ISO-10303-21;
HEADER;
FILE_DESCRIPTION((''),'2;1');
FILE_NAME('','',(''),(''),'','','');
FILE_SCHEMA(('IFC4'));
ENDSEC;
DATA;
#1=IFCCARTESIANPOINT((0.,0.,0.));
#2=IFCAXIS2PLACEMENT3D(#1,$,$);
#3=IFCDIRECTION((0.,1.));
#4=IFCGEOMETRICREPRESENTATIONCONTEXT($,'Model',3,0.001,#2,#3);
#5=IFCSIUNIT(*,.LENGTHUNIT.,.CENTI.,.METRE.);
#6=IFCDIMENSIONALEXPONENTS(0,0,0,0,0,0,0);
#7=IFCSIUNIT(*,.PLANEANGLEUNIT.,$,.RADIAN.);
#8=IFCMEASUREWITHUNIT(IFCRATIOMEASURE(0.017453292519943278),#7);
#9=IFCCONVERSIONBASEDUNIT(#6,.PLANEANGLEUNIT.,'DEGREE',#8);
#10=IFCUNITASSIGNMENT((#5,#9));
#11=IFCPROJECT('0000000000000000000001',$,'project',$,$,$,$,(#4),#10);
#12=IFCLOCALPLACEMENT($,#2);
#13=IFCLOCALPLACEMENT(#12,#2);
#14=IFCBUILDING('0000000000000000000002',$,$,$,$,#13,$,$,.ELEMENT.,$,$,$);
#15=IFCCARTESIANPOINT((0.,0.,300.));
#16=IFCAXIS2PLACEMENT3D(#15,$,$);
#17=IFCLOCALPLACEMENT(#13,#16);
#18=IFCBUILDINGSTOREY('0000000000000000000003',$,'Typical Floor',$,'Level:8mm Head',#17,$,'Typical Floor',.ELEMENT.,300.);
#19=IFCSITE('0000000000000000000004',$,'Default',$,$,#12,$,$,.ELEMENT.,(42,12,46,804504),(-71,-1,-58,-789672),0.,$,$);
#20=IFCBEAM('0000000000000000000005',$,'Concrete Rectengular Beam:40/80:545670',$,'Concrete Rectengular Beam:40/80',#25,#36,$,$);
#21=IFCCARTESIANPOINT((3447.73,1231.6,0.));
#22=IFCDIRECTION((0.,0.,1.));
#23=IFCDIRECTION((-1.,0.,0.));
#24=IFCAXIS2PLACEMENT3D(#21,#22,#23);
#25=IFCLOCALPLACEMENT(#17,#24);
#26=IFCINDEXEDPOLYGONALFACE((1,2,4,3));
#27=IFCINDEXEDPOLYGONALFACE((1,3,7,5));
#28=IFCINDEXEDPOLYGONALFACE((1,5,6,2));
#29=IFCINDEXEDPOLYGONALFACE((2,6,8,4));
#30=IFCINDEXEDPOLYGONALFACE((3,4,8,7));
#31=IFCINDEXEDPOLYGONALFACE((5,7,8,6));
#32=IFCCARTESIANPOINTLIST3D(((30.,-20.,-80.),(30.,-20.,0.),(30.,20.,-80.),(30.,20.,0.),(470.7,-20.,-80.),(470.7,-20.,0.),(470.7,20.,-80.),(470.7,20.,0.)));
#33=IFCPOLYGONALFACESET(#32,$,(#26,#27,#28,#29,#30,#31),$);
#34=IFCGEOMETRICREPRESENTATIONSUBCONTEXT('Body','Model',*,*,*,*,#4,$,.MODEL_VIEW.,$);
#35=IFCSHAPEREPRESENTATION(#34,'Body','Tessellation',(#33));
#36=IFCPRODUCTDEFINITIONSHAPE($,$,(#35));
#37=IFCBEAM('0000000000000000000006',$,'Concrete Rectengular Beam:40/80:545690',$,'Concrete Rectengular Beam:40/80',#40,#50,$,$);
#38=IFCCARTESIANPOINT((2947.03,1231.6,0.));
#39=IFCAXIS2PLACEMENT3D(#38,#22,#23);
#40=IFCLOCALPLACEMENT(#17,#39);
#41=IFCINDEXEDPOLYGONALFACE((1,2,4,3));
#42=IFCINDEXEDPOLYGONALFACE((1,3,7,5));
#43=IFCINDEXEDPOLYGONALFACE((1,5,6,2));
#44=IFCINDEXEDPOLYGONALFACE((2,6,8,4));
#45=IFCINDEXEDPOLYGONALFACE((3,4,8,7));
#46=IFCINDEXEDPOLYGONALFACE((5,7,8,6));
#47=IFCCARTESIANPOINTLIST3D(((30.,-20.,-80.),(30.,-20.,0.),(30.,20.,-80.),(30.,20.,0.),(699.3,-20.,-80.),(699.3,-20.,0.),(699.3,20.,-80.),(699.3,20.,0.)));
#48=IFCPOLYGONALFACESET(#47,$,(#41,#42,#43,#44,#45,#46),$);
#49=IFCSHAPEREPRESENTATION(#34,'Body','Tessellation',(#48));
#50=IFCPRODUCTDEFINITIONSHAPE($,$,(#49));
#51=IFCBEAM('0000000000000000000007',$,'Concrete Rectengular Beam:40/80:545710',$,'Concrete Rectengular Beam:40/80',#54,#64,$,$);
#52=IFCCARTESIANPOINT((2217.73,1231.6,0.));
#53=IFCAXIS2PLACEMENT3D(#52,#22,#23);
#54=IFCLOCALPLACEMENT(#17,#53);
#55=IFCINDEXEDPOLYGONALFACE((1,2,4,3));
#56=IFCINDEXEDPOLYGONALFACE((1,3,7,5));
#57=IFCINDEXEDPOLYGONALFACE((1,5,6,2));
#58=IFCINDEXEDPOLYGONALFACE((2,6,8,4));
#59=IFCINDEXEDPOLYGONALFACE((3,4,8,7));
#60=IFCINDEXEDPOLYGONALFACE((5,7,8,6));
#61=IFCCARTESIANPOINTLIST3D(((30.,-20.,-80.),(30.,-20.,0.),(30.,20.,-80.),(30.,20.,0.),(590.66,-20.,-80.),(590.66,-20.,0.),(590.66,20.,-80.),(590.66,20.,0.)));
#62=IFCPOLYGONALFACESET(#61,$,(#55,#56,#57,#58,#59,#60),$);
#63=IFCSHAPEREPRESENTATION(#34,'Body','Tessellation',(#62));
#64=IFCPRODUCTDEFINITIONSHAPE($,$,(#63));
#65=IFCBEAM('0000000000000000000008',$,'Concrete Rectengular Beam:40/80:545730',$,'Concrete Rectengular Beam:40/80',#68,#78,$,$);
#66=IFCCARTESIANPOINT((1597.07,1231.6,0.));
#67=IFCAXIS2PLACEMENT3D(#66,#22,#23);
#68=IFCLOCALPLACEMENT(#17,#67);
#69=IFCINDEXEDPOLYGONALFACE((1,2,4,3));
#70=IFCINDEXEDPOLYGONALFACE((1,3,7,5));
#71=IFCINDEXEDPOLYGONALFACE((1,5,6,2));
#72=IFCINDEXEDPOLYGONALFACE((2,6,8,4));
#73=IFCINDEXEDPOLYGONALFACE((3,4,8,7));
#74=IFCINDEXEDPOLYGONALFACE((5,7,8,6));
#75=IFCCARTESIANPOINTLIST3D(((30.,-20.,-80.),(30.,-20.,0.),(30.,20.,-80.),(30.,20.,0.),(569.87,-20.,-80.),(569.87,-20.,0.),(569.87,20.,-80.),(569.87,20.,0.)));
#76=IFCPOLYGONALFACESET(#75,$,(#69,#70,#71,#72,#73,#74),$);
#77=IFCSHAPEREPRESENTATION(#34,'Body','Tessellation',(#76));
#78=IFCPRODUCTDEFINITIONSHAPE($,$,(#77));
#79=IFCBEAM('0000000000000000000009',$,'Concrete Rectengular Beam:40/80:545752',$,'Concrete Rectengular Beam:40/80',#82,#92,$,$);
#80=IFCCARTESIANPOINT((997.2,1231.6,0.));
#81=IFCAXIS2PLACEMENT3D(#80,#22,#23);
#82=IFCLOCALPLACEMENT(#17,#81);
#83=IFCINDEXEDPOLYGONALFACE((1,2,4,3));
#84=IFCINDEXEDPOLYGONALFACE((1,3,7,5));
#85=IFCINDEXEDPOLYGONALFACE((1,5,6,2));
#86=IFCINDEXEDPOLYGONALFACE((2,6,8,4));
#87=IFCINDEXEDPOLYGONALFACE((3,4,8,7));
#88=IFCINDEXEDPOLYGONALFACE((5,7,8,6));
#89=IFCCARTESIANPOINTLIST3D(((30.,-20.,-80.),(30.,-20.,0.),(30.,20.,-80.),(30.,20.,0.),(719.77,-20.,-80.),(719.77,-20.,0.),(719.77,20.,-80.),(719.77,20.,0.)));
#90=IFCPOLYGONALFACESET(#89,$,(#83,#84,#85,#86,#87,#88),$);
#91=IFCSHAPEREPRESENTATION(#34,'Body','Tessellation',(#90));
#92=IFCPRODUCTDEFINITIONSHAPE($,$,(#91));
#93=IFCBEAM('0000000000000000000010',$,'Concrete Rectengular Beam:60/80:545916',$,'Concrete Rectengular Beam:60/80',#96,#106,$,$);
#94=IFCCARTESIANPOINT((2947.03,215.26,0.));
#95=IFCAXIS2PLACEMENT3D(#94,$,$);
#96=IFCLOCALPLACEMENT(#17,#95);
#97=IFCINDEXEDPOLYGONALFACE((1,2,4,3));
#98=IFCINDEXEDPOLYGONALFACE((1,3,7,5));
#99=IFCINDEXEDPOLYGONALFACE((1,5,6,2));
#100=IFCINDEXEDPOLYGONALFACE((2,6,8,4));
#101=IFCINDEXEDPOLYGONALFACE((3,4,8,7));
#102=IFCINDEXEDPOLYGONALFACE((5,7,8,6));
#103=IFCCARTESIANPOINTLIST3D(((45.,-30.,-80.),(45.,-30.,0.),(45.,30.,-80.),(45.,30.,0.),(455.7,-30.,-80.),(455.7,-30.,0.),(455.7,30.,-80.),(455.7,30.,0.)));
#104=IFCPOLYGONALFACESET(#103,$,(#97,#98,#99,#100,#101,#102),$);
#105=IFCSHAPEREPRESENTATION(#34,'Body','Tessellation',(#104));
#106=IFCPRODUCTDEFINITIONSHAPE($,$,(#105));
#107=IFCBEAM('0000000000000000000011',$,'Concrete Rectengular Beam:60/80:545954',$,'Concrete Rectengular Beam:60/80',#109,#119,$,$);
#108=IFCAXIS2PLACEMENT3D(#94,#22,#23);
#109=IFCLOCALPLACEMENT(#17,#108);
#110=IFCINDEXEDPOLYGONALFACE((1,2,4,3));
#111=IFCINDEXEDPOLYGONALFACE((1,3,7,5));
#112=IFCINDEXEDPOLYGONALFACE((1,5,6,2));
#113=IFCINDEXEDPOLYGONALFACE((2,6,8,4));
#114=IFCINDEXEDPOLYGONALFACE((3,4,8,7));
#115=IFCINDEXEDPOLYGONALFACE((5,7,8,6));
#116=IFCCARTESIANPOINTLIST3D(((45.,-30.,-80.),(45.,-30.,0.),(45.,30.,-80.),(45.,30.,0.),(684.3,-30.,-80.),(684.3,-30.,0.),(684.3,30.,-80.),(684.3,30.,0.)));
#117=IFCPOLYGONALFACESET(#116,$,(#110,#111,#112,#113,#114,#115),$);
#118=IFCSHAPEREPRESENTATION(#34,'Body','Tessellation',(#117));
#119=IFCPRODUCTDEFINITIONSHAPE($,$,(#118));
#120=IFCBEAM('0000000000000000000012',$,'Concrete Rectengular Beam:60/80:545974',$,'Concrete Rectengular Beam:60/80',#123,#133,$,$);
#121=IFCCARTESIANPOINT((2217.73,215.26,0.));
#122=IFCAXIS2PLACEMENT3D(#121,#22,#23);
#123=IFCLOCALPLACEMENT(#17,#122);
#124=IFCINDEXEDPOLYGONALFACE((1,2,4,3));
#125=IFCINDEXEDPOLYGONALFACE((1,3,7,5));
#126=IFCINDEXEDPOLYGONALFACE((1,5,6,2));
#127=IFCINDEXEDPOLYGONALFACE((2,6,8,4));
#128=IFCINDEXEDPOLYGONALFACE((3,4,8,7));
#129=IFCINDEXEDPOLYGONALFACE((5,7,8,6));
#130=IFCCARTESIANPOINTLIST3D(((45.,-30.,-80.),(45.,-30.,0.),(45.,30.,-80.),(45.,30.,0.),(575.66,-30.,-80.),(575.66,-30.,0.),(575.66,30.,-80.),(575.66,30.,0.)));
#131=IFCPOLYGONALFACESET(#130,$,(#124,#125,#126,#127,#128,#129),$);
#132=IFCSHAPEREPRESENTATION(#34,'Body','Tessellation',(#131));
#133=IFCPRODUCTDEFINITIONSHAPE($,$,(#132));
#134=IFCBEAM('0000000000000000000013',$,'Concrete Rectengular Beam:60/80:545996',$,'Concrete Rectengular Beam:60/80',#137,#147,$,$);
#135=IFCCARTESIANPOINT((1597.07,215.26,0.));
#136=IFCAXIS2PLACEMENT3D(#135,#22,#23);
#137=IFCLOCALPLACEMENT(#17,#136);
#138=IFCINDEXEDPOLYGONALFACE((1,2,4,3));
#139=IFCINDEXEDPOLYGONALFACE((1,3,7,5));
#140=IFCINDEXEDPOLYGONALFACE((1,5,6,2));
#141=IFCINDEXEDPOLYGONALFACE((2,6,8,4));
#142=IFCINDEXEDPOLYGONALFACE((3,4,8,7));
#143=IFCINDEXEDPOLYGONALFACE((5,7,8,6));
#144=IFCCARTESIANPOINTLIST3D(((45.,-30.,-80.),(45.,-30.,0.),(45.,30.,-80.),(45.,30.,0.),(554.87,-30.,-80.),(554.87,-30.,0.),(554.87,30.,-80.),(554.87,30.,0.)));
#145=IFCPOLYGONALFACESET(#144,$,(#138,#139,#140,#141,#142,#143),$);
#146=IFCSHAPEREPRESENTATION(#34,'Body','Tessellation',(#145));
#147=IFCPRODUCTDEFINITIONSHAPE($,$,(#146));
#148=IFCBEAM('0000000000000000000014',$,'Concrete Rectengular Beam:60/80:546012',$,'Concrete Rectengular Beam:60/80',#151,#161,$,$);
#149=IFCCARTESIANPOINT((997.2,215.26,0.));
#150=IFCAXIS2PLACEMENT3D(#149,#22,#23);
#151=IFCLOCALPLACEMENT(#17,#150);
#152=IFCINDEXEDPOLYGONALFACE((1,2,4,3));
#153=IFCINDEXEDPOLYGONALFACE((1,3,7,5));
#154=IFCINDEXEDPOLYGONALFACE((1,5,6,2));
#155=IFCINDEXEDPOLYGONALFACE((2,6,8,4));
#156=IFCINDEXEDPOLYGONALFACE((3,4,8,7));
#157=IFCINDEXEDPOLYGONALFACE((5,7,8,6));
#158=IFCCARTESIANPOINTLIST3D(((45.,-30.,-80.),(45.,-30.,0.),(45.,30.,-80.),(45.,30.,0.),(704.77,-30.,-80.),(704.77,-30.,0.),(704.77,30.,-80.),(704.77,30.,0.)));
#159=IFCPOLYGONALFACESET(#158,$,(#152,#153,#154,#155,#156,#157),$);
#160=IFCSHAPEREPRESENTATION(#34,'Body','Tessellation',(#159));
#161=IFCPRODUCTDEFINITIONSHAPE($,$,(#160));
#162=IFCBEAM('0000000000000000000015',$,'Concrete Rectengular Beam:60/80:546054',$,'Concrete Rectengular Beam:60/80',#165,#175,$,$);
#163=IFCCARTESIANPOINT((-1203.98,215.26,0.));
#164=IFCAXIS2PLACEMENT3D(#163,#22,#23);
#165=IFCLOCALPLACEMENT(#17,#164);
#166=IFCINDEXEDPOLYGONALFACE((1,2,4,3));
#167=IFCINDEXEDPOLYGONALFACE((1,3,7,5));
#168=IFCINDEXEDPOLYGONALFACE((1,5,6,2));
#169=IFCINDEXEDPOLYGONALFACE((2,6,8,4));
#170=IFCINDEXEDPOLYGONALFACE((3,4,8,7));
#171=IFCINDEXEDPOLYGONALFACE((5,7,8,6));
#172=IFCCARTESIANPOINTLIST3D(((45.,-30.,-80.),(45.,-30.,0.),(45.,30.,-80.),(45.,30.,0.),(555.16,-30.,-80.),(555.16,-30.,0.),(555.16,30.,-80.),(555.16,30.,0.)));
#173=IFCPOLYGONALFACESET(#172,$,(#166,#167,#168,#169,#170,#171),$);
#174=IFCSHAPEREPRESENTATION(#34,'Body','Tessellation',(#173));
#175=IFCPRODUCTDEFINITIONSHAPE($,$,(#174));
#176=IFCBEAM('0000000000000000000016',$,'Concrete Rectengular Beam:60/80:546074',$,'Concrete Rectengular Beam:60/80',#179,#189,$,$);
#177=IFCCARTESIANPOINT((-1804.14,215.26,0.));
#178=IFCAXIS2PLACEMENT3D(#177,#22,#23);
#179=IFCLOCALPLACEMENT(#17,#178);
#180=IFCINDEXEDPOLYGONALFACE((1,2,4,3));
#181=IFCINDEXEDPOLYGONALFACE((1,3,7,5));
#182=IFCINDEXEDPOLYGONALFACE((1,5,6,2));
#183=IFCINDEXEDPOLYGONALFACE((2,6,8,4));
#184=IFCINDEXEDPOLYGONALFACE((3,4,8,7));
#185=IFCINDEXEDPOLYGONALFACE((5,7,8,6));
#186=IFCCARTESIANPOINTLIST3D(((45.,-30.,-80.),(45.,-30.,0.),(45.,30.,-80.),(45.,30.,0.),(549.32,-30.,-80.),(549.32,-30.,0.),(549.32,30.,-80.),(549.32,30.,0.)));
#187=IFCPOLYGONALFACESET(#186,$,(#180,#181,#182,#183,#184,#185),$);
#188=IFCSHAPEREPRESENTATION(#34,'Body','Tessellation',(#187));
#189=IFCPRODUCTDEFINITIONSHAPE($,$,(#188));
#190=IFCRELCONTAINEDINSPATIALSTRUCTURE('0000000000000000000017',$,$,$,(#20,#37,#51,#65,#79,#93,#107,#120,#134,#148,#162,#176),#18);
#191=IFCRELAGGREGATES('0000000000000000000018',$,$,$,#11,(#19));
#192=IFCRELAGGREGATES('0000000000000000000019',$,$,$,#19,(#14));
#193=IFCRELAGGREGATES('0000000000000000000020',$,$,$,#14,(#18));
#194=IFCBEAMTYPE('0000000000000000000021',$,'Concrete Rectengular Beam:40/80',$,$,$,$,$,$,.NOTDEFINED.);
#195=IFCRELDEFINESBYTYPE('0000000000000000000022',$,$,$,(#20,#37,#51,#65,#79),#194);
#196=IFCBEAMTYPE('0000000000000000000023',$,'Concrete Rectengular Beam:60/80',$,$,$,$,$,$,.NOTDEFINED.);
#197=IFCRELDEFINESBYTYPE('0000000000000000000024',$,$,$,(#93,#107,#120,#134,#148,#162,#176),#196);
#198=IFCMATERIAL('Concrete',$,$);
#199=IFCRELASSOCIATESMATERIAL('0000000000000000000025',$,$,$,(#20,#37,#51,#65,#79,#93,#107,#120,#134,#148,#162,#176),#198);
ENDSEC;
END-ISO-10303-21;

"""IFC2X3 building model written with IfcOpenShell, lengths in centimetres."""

from ifc_helpers import new_model, entity, si_unit, converted_unit, direction, frame, frame_2d, origin, place, context, subcontext, project, spatial, rectangle, extrude, material, type_object, element, save


model = new_model("IFC2X3")

# Units and contexts
model_context = context("Model", 3, precision=0.001, world=origin(), true_north=direction((0.0, 1.0)))
body_context = subcontext(model_context, "Body", "Model", "MODEL_VIEW")
ifc_project = project(units=[si_unit("LENGTHUNIT", "METRE", prefix="CENTI"), converted_unit("PLANEANGLEUNIT", "DEGREE", entity("IfcRatioMeasure", 0.017453292519943278), si_unit("PLANEANGLEUNIT", "RADIAN"), dimensions=[0, 0, 0, 0, 0, 0, 0])], contexts=[model_context])

# Site, building, storey
site_placement = place(None, origin())
site = spatial("IfcSite", under=ifc_project, at=site_placement, Name="Default", CompositionType="ELEMENT", RefLatitude=(42, 12, 46, 804504), RefLongitude=(-71, -1, -58, -789672), RefElevation=0.0)
building_placement = place(site_placement, origin())
building = spatial("IfcBuilding", under=site, at=building_placement, CompositionType="ELEMENT")
storey_placement = place(building_placement, frame((0.0, 0.0, 300.0)))
storey = spatial("IfcBuildingStorey", under=building, at=storey_placement, Name="Typical Floor", ObjectType="Level:8mm Head", LongName="Typical Floor", CompositionType="ELEMENT", Elevation=300.0)

# Beams
ifc_material = material(Name="Concrete")
beam_type_1 = type_object("IfcBeamType", Name="Concrete Rectengular Beam:40/80", PredefinedType="NOTDEFINED")
beam_1_placement = place(storey_placement, frame((3447.73, 1231.6, 0.0), z_axis=(0.0, 0.0, 1.0), x_axis=(-1.0, 0.0, 0.0)))
element("IfcBeam", 1, at=beam_1_placement, inside=storey, type_object=beam_type_1, material=ifc_material, Name="Concrete Rectengular Beam:40/80:545670", ObjectType="Concrete Rectengular Beam:40/80", context=body_context, shape_type="SweptSolid", body=[
    extrude(rectangle(XDim=80.0, YDim=40.0, at=frame_2d((0.0, 0.0), x_axis=(1.0, 0.0))), frame((30.0, 0.0, -40.0), z_axis=(1.0, 0.0, 0.0), x_axis=(0.0, 0.0, -1.0)), (0.0, 0.0, 1.0), 440.7),
])
beam_2_placement = place(storey_placement, frame((2947.03, 1231.6, 0.0), z_axis=(0.0, 0.0, 1.0), x_axis=(-1.0, 0.0, 0.0)))
element("IfcBeam", 2, at=beam_2_placement, inside=storey, type_object=beam_type_1, material=ifc_material, Name="Concrete Rectengular Beam:40/80:545690", ObjectType="Concrete Rectengular Beam:40/80", context=body_context, shape_type="SweptSolid", body=[
    extrude(rectangle(XDim=80.0, YDim=40.0, at=frame_2d((0.0, 0.0), x_axis=(1.0, 0.0))), frame((30.0, 0.0, -40.0), z_axis=(1.0, 0.0, 0.0), x_axis=(0.0, 0.0, -1.0)), (0.0, 0.0, 1.0), 669.3),
])
beam_3_placement = place(storey_placement, frame((2217.73, 1231.6, 0.0), z_axis=(0.0, 0.0, 1.0), x_axis=(-1.0, 0.0, 0.0)))
element("IfcBeam", 3, at=beam_3_placement, inside=storey, type_object=beam_type_1, material=ifc_material, Name="Concrete Rectengular Beam:40/80:545710", ObjectType="Concrete Rectengular Beam:40/80", context=body_context, shape_type="SweptSolid", body=[
    extrude(rectangle(XDim=80.0, YDim=40.0, at=frame_2d((0.0, 0.0), x_axis=(1.0, 0.0))), frame((30.0, 0.0, -40.0), z_axis=(1.0, 0.0, 0.0), x_axis=(0.0, 0.0, -1.0)), (0.0, 0.0, 1.0), 560.66),
])
beam_4_placement = place(storey_placement, frame((1597.07, 1231.6, 0.0), z_axis=(0.0, 0.0, 1.0), x_axis=(-1.0, 0.0, 0.0)))
element("IfcBeam", 4, at=beam_4_placement, inside=storey, type_object=beam_type_1, material=ifc_material, Name="Concrete Rectengular Beam:40/80:545730", ObjectType="Concrete Rectengular Beam:40/80", context=body_context, shape_type="SweptSolid", body=[
    extrude(rectangle(XDim=80.0, YDim=40.0, at=frame_2d((0.0, 0.0), x_axis=(1.0, 0.0))), frame((30.0, 0.0, -40.0), z_axis=(1.0, 0.0, 0.0), x_axis=(0.0, 0.0, -1.0)), (0.0, 0.0, 1.0), 539.87),
])
beam_5_placement = place(storey_placement, frame((997.2, 1231.6, 0.0), z_axis=(0.0, 0.0, 1.0), x_axis=(-1.0, 0.0, 0.0)))
element("IfcBeam", 5, at=beam_5_placement, inside=storey, type_object=beam_type_1, material=ifc_material, Name="Concrete Rectengular Beam:40/80:545752", ObjectType="Concrete Rectengular Beam:40/80", context=body_context, shape_type="SweptSolid", body=[
    extrude(rectangle(XDim=80.0, YDim=40.0, at=frame_2d((0.0, 0.0), x_axis=(1.0, 0.0))), frame((30.0, 0.0, -40.0), z_axis=(1.0, 0.0, 0.0), x_axis=(0.0, 0.0, -1.0)), (0.0, 0.0, 1.0), 689.77),
])
beam_type_2 = type_object("IfcBeamType", Name="Concrete Rectengular Beam:60/80", PredefinedType="NOTDEFINED")
beam_6_placement = place(storey_placement, frame((2947.03, 215.26, 0.0)))
element("IfcBeam", 6, at=beam_6_placement, inside=storey, type_object=beam_type_2, material=ifc_material, Name="Concrete Rectengular Beam:60/80:545916", ObjectType="Concrete Rectengular Beam:60/80", context=body_context, shape_type="SweptSolid", body=[
    extrude(rectangle(XDim=80.0, YDim=60.0, at=frame_2d((0.0, 0.0), x_axis=(1.0, 0.0))), frame((45.0, 0.0, -40.0), z_axis=(1.0, 0.0, 0.0), x_axis=(0.0, 0.0, -1.0)), (0.0, 0.0, 1.0), 410.7),
])
beam_7_placement = place(storey_placement, frame((2947.03, 215.26, 0.0), z_axis=(0.0, 0.0, 1.0), x_axis=(-1.0, 0.0, 0.0)))
element("IfcBeam", 7, at=beam_7_placement, inside=storey, type_object=beam_type_2, material=ifc_material, Name="Concrete Rectengular Beam:60/80:545954", ObjectType="Concrete Rectengular Beam:60/80", context=body_context, shape_type="SweptSolid", body=[
    extrude(rectangle(XDim=80.0, YDim=60.0, at=frame_2d((0.0, 0.0), x_axis=(1.0, 0.0))), frame((45.0, 0.0, -40.0), z_axis=(1.0, 0.0, 0.0), x_axis=(0.0, 0.0, -1.0)), (0.0, 0.0, 1.0), 639.3),
])
beam_8_placement = place(storey_placement, frame((2217.73, 215.26, 0.0), z_axis=(0.0, 0.0, 1.0), x_axis=(-1.0, 0.0, 0.0)))
element("IfcBeam", 8, at=beam_8_placement, inside=storey, type_object=beam_type_2, material=ifc_material, Name="Concrete Rectengular Beam:60/80:545974", ObjectType="Concrete Rectengular Beam:60/80", context=body_context, shape_type="SweptSolid", body=[
    extrude(rectangle(XDim=80.0, YDim=60.0, at=frame_2d((0.0, 0.0), x_axis=(1.0, 0.0))), frame((45.0, 0.0, -40.0), z_axis=(1.0, 0.0, 0.0), x_axis=(0.0, 0.0, -1.0)), (0.0, 0.0, 1.0), 530.66),
])
beam_9_placement = place(storey_placement, frame((1597.07, 215.26, 0.0), z_axis=(0.0, 0.0, 1.0), x_axis=(-1.0, 0.0, 0.0)))
element("IfcBeam", 9, at=beam_9_placement, inside=storey, type_object=beam_type_2, material=ifc_material, Name="Concrete Rectengular Beam:60/80:545996", ObjectType="Concrete Rectengular Beam:60/80", context=body_context, shape_type="SweptSolid", body=[
    extrude(rectangle(XDim=80.0, YDim=60.0, at=frame_2d((0.0, 0.0), x_axis=(1.0, 0.0))), frame((45.0, 0.0, -40.0), z_axis=(1.0, 0.0, 0.0), x_axis=(0.0, 0.0, -1.0)), (0.0, 0.0, 1.0), 509.87),
])
beam_10_placement = place(storey_placement, frame((997.2, 215.26, 0.0), z_axis=(0.0, 0.0, 1.0), x_axis=(-1.0, 0.0, 0.0)))
element("IfcBeam", 10, at=beam_10_placement, inside=storey, type_object=beam_type_2, material=ifc_material, Name="Concrete Rectengular Beam:60/80:546012", ObjectType="Concrete Rectengular Beam:60/80", context=body_context, shape_type="SweptSolid", body=[
    extrude(rectangle(XDim=80.0, YDim=60.0, at=frame_2d((0.0, 0.0), x_axis=(1.0, 0.0))), frame((45.0, 0.0, -40.0), z_axis=(1.0, 0.0, 0.0), x_axis=(0.0, 0.0, -1.0)), (0.0, 0.0, 1.0), 659.77),
])
beam_11_placement = place(storey_placement, frame((-1203.98, 215.26, 0.0), z_axis=(0.0, 0.0, 1.0), x_axis=(-1.0, 0.0, 0.0)))
element("IfcBeam", 11, at=beam_11_placement, inside=storey, type_object=beam_type_2, material=ifc_material, Name="Concrete Rectengular Beam:60/80:546054", ObjectType="Concrete Rectengular Beam:60/80", context=body_context, shape_type="SweptSolid", body=[
    extrude(rectangle(XDim=80.0, YDim=60.0, at=frame_2d((0.0, 0.0), x_axis=(1.0, 0.0))), frame((45.0, 0.0, -40.0), z_axis=(1.0, 0.0, 0.0), x_axis=(0.0, 0.0, -1.0)), (0.0, 0.0, 1.0), 510.16),
])
beam_12_placement = place(storey_placement, frame((-1804.14, 215.26, 0.0), z_axis=(0.0, 0.0, 1.0), x_axis=(-1.0, 0.0, 0.0)))
element("IfcBeam", 12, at=beam_12_placement, inside=storey, type_object=beam_type_2, material=ifc_material, Name="Concrete Rectengular Beam:60/80:546074", ObjectType="Concrete Rectengular Beam:60/80", context=body_context, shape_type="SweptSolid", body=[
    extrude(rectangle(XDim=80.0, YDim=60.0, at=frame_2d((0.0, 0.0), x_axis=(1.0, 0.0))), frame((45.0, 0.0, -40.0), z_axis=(1.0, 0.0, 0.0), x_axis=(0.0, 0.0, -1.0)), (0.0, 0.0, 1.0), 504.32),
])

save(model, "model.ifc")
